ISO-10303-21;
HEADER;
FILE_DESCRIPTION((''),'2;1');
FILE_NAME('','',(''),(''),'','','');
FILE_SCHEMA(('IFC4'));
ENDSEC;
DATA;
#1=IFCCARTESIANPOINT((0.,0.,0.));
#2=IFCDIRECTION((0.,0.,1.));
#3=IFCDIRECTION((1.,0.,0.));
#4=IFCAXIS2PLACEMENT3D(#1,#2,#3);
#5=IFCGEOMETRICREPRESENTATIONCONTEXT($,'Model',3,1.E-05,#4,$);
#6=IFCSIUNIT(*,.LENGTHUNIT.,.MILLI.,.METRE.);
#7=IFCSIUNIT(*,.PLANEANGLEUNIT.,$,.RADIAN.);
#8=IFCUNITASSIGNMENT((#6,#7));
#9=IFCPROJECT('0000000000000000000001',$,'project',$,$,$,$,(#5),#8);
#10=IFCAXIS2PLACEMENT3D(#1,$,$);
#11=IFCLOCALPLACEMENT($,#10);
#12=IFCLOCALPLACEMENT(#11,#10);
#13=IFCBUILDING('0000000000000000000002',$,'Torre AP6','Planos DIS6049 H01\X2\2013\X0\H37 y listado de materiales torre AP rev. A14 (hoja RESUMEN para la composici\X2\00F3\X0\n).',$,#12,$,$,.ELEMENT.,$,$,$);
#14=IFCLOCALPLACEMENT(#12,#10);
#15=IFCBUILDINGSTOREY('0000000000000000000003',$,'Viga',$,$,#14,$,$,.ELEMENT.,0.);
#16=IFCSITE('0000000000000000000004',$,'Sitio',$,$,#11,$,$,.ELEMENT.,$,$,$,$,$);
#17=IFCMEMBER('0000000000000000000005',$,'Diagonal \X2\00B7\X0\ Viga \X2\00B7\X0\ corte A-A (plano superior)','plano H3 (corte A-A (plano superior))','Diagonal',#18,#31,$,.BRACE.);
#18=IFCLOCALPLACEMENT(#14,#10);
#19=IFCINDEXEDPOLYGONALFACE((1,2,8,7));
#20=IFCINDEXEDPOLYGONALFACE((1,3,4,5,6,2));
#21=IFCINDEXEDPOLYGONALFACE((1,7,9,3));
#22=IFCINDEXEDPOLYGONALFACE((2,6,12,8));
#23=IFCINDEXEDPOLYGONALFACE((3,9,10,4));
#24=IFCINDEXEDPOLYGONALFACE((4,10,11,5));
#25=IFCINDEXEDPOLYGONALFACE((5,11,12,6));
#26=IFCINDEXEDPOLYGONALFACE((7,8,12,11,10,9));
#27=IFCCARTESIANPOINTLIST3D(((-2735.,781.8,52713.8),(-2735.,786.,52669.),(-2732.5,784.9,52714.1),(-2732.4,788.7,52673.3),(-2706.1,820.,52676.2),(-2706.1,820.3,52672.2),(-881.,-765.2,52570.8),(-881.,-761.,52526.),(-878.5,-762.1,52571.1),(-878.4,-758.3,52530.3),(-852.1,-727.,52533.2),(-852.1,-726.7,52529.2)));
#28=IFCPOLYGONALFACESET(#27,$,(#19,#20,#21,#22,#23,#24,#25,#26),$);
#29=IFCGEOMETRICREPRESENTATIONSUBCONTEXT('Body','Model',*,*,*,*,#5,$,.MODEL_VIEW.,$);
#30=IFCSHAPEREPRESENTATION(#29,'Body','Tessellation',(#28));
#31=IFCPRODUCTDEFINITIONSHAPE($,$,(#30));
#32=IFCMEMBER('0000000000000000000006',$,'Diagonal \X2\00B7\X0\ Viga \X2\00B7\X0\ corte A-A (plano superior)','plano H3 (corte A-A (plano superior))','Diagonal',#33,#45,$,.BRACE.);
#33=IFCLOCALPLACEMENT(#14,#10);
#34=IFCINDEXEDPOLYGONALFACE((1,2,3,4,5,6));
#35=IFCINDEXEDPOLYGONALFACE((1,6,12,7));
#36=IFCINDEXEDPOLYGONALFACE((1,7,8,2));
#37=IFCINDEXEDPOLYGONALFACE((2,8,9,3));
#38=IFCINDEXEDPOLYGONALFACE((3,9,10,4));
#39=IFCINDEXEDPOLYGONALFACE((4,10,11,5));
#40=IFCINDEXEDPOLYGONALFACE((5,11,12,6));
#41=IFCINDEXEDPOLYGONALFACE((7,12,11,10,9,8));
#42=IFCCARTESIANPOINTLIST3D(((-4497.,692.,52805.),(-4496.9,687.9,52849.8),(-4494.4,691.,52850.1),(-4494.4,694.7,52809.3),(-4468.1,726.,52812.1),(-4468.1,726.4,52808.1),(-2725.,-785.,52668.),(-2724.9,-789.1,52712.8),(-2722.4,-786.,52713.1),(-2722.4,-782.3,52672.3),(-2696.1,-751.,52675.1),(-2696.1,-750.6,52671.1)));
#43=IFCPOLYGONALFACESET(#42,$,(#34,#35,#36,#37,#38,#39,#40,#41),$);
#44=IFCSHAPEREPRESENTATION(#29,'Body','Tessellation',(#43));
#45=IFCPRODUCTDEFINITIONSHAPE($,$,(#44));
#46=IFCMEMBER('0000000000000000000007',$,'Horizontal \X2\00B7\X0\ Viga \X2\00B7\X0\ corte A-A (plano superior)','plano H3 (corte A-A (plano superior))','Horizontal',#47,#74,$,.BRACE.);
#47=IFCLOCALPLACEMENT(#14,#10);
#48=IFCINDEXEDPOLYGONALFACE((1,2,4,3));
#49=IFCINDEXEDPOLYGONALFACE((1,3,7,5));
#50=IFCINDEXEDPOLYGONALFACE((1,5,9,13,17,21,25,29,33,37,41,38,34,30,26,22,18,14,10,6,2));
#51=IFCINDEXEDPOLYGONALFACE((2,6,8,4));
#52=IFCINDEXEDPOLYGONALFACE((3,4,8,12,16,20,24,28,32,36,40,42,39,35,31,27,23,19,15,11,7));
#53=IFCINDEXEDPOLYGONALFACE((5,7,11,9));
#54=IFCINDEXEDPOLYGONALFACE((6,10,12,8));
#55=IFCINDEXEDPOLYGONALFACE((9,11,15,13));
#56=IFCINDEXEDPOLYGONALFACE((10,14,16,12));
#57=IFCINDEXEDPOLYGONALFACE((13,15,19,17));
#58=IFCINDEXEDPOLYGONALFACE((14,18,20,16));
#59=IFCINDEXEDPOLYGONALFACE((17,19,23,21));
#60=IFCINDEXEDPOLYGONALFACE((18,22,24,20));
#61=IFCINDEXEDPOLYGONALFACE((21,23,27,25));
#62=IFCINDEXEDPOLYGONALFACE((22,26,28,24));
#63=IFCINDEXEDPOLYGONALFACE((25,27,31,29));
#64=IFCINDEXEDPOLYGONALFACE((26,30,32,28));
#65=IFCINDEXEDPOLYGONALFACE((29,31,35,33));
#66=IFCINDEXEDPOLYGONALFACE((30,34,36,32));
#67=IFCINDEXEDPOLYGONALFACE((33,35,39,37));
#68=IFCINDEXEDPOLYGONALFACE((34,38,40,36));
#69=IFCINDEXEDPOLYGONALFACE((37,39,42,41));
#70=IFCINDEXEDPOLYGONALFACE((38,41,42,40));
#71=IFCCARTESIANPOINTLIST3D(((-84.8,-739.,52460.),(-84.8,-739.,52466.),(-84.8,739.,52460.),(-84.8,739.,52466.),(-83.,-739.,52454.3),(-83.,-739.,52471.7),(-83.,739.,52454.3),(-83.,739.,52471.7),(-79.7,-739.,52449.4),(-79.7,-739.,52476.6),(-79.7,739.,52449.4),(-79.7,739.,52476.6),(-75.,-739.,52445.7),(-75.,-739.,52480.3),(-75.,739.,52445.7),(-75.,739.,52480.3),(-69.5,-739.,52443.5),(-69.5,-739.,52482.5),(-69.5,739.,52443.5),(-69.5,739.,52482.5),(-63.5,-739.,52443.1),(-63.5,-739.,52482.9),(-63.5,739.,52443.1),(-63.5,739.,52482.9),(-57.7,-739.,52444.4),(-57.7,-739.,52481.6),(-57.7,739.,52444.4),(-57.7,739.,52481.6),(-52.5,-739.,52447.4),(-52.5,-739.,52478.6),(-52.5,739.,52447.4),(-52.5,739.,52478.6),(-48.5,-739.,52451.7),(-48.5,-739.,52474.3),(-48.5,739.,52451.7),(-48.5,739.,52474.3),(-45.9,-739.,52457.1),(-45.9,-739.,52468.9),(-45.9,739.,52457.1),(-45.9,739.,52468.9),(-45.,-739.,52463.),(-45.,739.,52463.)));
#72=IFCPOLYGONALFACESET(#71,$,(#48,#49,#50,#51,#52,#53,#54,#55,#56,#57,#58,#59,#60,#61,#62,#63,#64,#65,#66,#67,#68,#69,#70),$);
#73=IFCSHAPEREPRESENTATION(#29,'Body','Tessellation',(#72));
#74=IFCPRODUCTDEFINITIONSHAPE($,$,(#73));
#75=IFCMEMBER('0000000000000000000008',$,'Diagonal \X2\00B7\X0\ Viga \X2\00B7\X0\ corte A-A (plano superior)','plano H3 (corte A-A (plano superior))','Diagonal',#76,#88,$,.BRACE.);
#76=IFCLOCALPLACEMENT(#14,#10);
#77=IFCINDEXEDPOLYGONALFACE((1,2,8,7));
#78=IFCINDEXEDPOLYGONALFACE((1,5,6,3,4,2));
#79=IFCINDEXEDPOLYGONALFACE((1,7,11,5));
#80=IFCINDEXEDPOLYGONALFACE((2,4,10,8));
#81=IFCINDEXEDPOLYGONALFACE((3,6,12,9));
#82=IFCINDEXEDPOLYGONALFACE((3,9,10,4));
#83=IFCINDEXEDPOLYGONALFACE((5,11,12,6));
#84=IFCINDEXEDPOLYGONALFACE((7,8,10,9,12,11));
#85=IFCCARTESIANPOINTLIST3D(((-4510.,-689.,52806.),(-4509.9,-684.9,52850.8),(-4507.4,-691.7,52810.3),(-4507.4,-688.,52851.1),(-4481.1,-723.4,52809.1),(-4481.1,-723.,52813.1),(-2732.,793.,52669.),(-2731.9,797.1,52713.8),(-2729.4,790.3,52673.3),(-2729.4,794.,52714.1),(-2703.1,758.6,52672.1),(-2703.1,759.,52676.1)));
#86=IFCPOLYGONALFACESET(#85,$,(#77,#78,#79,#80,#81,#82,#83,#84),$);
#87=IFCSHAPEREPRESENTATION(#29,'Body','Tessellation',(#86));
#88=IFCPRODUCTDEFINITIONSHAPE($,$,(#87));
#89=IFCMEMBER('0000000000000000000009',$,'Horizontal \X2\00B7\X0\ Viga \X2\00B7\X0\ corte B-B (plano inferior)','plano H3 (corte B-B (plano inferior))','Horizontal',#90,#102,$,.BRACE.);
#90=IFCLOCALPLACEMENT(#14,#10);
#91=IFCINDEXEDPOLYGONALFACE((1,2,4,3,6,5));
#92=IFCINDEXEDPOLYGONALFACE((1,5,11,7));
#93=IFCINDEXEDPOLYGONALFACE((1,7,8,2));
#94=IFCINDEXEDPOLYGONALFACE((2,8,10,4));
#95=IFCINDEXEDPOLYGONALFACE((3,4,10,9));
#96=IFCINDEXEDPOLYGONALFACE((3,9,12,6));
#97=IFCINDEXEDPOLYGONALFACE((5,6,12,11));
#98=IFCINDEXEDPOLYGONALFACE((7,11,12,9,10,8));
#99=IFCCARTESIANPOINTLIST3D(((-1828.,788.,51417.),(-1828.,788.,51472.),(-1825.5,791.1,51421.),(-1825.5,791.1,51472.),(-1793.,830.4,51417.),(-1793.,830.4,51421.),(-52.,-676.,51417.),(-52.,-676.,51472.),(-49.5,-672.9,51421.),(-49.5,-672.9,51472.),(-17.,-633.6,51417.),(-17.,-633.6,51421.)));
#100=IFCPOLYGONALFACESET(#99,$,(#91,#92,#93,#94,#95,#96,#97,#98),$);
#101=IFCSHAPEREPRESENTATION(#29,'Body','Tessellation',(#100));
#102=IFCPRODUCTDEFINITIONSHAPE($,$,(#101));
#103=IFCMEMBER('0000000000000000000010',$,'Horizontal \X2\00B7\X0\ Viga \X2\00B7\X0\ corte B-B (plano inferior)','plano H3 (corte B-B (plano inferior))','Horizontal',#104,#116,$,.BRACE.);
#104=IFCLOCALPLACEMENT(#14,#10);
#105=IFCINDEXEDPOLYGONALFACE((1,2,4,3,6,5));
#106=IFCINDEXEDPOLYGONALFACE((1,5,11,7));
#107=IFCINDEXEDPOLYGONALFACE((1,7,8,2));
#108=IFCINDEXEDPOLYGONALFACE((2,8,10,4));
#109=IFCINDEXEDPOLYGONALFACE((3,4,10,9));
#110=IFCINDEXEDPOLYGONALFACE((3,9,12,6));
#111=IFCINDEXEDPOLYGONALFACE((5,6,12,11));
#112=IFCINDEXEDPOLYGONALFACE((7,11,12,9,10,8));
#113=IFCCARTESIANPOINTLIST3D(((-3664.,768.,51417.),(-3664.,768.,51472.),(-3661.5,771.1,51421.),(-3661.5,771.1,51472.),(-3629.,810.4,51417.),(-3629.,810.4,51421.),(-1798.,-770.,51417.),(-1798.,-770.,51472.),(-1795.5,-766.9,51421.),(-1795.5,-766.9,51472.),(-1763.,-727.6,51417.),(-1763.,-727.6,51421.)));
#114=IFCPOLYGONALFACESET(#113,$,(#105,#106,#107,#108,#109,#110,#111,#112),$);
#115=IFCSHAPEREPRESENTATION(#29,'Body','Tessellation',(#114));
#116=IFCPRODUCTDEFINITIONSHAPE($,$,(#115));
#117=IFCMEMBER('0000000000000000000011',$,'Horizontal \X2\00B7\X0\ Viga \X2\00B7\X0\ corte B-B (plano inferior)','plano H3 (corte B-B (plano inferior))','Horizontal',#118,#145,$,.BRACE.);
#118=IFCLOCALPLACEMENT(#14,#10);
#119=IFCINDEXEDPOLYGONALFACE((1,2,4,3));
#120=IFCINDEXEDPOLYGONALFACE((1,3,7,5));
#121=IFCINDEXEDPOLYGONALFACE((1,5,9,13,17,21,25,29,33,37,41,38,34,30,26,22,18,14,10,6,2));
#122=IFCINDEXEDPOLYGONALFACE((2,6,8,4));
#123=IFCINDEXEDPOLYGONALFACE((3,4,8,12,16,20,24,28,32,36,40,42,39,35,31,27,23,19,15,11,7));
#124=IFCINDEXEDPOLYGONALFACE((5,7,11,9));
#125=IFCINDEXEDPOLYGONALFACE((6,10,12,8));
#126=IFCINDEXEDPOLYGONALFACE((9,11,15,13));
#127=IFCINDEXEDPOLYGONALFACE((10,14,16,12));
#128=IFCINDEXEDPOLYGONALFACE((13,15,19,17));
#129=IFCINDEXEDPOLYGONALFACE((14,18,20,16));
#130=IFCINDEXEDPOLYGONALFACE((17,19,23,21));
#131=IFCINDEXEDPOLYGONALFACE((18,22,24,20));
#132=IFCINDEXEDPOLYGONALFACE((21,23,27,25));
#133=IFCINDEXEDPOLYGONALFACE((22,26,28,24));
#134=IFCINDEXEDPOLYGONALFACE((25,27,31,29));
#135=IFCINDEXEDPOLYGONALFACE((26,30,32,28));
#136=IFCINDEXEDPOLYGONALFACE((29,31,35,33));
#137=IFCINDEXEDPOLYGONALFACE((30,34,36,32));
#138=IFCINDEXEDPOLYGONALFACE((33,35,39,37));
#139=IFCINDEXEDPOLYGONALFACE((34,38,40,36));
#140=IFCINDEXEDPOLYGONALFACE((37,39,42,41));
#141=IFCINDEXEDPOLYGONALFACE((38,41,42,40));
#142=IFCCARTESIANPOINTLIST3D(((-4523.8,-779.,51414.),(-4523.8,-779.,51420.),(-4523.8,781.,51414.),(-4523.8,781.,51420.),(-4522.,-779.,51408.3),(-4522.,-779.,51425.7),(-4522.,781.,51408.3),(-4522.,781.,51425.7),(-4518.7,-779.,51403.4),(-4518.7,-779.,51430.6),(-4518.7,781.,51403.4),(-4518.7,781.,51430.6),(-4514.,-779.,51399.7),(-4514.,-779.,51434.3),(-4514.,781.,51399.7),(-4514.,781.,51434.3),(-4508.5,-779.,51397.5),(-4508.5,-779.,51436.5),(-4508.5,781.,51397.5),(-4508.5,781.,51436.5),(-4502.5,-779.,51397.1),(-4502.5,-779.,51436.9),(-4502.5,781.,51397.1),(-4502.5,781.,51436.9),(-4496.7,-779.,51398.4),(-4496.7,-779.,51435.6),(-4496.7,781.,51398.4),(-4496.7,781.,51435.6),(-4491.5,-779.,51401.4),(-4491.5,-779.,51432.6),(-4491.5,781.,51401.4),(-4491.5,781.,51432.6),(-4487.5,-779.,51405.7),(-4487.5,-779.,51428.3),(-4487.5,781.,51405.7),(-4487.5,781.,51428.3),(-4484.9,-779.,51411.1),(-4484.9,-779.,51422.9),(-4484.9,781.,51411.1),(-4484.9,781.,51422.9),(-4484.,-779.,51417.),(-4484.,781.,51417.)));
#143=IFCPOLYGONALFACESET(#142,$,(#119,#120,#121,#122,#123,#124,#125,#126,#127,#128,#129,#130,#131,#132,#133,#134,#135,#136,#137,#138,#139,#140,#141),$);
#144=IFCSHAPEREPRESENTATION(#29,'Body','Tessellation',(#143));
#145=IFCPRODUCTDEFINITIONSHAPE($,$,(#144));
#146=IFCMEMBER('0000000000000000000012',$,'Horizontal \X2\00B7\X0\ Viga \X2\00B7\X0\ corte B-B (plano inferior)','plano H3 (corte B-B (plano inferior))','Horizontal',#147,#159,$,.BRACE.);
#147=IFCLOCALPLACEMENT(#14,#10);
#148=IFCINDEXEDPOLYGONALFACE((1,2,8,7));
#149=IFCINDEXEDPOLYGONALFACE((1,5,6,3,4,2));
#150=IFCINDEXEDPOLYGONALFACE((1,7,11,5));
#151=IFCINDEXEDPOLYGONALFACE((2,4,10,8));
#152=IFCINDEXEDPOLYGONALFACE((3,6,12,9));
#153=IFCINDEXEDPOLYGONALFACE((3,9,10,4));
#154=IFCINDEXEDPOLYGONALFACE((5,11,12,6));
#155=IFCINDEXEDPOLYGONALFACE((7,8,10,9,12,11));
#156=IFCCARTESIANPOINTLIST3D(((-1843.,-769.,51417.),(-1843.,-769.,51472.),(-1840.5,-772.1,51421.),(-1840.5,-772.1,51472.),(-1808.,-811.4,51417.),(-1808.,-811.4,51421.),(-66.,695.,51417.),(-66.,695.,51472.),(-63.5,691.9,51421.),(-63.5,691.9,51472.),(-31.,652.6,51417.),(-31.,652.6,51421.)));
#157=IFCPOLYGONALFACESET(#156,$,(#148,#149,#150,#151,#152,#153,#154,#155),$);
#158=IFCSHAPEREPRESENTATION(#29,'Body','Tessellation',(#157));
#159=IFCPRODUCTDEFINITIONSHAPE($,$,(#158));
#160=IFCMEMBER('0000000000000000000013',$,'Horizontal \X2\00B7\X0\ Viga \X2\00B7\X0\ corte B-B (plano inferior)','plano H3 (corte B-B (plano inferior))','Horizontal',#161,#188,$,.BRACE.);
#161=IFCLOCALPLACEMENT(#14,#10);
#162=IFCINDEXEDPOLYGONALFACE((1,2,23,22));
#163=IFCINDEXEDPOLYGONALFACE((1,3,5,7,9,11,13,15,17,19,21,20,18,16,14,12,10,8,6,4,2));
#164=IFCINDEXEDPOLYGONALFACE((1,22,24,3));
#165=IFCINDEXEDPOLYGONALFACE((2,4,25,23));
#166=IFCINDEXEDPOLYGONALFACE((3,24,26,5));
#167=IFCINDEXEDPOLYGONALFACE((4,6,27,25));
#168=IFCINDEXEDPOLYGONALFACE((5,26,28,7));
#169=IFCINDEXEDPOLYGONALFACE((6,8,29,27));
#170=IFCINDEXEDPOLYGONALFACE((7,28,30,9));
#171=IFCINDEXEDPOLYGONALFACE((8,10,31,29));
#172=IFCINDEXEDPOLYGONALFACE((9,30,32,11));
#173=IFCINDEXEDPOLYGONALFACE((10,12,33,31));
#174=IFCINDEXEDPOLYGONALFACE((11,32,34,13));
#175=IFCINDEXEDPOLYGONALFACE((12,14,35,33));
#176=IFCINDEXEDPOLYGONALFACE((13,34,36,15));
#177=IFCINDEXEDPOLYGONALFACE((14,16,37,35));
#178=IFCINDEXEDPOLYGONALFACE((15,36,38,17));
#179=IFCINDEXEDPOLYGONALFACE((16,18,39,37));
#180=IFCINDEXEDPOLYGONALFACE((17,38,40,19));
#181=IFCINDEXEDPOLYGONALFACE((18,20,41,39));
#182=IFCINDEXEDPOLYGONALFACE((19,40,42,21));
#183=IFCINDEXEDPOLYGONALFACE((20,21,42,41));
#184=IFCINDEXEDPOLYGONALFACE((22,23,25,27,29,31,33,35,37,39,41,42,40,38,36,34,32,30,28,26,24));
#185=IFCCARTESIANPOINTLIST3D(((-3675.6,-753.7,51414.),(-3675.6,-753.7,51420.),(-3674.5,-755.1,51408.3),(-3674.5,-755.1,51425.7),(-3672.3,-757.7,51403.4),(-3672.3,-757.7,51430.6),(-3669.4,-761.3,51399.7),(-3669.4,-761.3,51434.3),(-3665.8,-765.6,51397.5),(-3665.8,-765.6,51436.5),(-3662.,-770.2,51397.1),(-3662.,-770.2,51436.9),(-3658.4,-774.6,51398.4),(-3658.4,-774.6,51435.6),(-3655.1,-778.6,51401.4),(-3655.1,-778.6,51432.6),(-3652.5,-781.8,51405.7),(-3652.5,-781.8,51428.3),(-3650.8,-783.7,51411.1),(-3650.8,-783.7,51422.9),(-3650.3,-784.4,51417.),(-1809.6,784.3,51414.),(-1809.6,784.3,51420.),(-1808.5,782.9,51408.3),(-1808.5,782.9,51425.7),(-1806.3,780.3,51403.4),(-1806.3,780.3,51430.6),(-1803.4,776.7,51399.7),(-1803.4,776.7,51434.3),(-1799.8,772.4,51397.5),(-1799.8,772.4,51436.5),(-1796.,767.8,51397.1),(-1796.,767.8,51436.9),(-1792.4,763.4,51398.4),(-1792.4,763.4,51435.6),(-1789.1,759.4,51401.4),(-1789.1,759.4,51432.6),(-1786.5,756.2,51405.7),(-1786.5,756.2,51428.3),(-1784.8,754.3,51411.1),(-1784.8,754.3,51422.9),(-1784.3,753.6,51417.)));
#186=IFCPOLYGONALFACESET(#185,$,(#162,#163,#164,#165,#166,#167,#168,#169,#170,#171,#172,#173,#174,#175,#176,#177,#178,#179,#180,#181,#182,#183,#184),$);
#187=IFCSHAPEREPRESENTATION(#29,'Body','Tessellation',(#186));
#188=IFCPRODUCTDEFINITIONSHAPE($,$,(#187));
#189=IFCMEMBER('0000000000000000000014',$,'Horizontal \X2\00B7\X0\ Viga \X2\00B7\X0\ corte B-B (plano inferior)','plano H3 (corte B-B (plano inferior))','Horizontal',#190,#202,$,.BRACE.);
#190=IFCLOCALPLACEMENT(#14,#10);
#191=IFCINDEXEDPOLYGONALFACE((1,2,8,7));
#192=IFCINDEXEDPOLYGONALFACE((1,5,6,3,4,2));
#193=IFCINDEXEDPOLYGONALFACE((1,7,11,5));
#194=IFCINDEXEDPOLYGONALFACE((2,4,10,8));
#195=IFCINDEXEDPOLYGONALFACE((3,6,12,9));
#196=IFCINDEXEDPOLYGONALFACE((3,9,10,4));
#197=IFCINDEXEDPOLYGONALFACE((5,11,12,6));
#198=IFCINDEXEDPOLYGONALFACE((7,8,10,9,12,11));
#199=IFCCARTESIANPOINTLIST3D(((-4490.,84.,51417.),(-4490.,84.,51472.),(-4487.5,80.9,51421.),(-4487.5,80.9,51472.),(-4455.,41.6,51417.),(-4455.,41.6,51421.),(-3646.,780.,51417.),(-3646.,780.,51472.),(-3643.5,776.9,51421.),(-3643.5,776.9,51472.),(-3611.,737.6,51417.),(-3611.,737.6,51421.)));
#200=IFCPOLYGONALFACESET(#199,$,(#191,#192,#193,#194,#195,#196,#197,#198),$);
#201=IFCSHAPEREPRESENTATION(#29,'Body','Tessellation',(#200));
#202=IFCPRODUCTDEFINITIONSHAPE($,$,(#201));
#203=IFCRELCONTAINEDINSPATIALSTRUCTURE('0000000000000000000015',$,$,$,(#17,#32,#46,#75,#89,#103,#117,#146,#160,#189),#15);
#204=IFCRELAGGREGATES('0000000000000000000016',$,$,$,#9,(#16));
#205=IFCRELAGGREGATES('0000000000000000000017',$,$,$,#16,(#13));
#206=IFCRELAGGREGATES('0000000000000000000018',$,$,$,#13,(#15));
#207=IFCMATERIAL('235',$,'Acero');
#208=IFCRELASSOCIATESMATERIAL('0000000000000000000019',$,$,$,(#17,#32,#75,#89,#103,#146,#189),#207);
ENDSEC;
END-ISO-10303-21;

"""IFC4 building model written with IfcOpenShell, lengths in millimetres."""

from ifc_helpers import new_model, si_unit, frame, frame_2d, origin, origin_with_axes, place, context, subcontext, project, spatial, circle, l_section, extrude, material, element, save


model = new_model("IFC4")

# Units and contexts
model_context = context("Model", 3, precision=1e-05, world=origin_with_axes())
body_context = subcontext(model_context, "Body", "Model", "MODEL_VIEW")
ifc_project = project(units=[si_unit("LENGTHUNIT", "METRE", prefix="MILLI"), si_unit("PLANEANGLEUNIT", "RADIAN")], contexts=[model_context])

# Site, building, storey
site_placement = place(None, origin())
site = spatial("IfcSite", under=ifc_project, at=site_placement, Name="Sitio", CompositionType="ELEMENT")
building_placement = place(site_placement, origin())
building = spatial("IfcBuilding", under=site, at=building_placement, Name="Torre AP6", Description="Planos DIS6049 H01–H37 y listado de materiales torre AP rev. A14 (hoja RESUMEN para la composición).", CompositionType="ELEMENT")
storey_placement = place(building_placement, origin())
storey = spatial("IfcBuildingStorey", under=building, at=storey_placement, Name="Viga", CompositionType="ELEMENT", Elevation=0.0)

# Members
ifc_material = material(Name="235", Category="Acero")
member_1_placement = place(storey_placement, frame((-2735.0, 786.0, 52669.0), z_axis=(0.766471, -0.639553, -0.059118), x_axis=(0.642279, 0.763125, 0.071544)))
element("IfcMember", 1, at=member_1_placement, inside=storey, material=ifc_material, Name="Diagonal · Viga · corte A-A (plano superior)", Description="plano H3 (corte A-A (plano superior))", ObjectType="Diagonal", PredefinedType="BRACE", context=body_context, shape_type="SweptSolid", body=[
    extrude(l_section(Depth=45.0, Width=45.0, Thickness=4.0, at=frame_2d((22.5, 22.5))), None, (0.0, 0.0, 1.0), 2418.9),
])
member_2_placement = place(storey_placement, frame((-4497.0, 692.0, 52805.0), z_axis=(0.766799, -0.639144, -0.059284), x_axis=(0.641886, 0.763689, 0.069004)))
element("IfcMember", 2, at=member_2_placement, inside=storey, material=ifc_material, Name="Diagonal · Viga · corte A-A (plano superior)", Description="plano H3 (corte A-A (plano superior))", ObjectType="Diagonal", PredefinedType="BRACE", context=body_context, shape_type="SweptSolid", body=[
    extrude(l_section(Depth=45.0, Width=45.0, Thickness=4.0, at=frame_2d((22.5, 22.5))), None, (0.0, 0.0, 1.0), 2310.9),
])
member_3_placement = place(storey_placement, frame((-65.0, 739.0, 52463.0), z_axis=(0.0, -1.0, 0.0), x_axis=(1.0, 0.0, 0.0)))
element("IfcMember", 3, at=member_3_placement, inside=storey, Name="Horizontal · Viga · corte A-A (plano superior)", Description="plano H3 (corte A-A (plano superior))", ObjectType="Horizontal", PredefinedType="BRACE", context=body_context, shape_type="SweptSolid", body=[
    extrude(circle(Radius=20.0), None, (0.0, 0.0, 1.0), 1478.0),
])
member_4_placement = place(storey_placement, frame((-2732.0, 793.0, 52669.0), z_axis=(-0.766808, -0.639151, 0.059085), x_axis=(0.641875, -0.763738, 0.068568)))
element("IfcMember", 4, at=member_4_placement, inside=storey, material=ifc_material, Name="Diagonal · Viga · corte A-A (plano superior)", Description="plano H3 (corte A-A (plano superior))", ObjectType="Diagonal", PredefinedType="BRACE", context=body_context, shape_type="SweptSolid", body=[
    extrude(l_section(Depth=45.0, Width=45.0, Thickness=4.0, at=frame_2d((22.5, 22.5))), None, (0.0, 0.0, 1.0), 2318.7),
])
member_5_placement = place(storey_placement, frame((-1828.0, 788.0, 51417.0), z_axis=(0.771629, -0.636073, 0.0), x_axis=(0.636073, 0.771629, 0.0)))
element("IfcMember", 5, at=member_5_placement, inside=storey, material=ifc_material, Name="Horizontal · Viga · corte B-B (plano inferior)", Description="plano H3 (corte B-B (plano inferior))", ObjectType="Horizontal", PredefinedType="BRACE", context=body_context, shape_type="SweptSolid", body=[
    extrude(l_section(Depth=55.0, Width=55.0, Thickness=4.0, at=frame_2d((27.5, 27.5))), None, (0.0, 0.0, 1.0), 2301.6),
])
member_6_placement = place(storey_placement, frame((-3664.0, 768.0, 51417.0), z_axis=(0.771668, -0.636026, 0.0), x_axis=(0.636026, 0.771668, 0.0)))
element("IfcMember", 6, at=member_6_placement, inside=storey, material=ifc_material, Name="Horizontal · Viga · corte B-B (plano inferior)", Description="plano H3 (corte B-B (plano inferior))", ObjectType="Horizontal", PredefinedType="BRACE", context=body_context, shape_type="SweptSolid", body=[
    extrude(l_section(Depth=55.0, Width=55.0, Thickness=4.0, at=frame_2d((27.5, 27.5))), None, (0.0, 0.0, 1.0), 2418.1),
])
member_7_placement = place(storey_placement, frame((-4504.0, 781.0, 51417.0), z_axis=(0.0, -1.0, 0.0), x_axis=(1.0, 0.0, 0.0)))
element("IfcMember", 7, at=member_7_placement, inside=storey, Name="Horizontal · Viga · corte B-B (plano inferior)", Description="plano H3 (corte B-B (plano inferior))", ObjectType="Horizontal", PredefinedType="BRACE", context=body_context, shape_type="SweptSolid", body=[
    extrude(circle(Radius=20.0), None, (0.0, 0.0, 1.0), 1560.0),
])
member_8_placement = place(storey_placement, frame((-66.0, 695.0, 51417.0), z_axis=(-0.771805, -0.635859, 0.0), x_axis=(0.635859, -0.771805, 0.0)))
element("IfcMember", 8, at=member_8_placement, inside=storey, material=ifc_material, Name="Horizontal · Viga · corte B-B (plano inferior)", Description="plano H3 (corte B-B (plano inferior))", ObjectType="Horizontal", PredefinedType="BRACE", context=body_context, shape_type="SweptSolid", body=[
    extrude(l_section(Depth=55.0, Width=55.0, Thickness=4.0, at=frame_2d((27.5, 27.5))), None, (0.0, 0.0, 1.0), 2302.4),
])
member_9_placement = place(storey_placement, frame((-1797.0, 769.0, 51417.0), z_axis=(-0.771668, -0.636026, 0.0), x_axis=(0.636026, -0.771668, 0.0)))
element("IfcMember", 9, at=member_9_placement, inside=storey, Name="Horizontal · Viga · corte B-B (plano inferior)", Description="plano H3 (corte B-B (plano inferior))", ObjectType="Horizontal", PredefinedType="BRACE", context=body_context, shape_type="SweptSolid", body=[
    extrude(circle(Radius=20.0), None, (0.0, 0.0, 1.0), 2418.1),
])
member_10_placement = place(storey_placement, frame((-3646.0, 780.0, 51417.0), z_axis=(-0.771508, -0.63622, 0.0), x_axis=(0.63622, -0.771508, 0.0)))
element("IfcMember", 10, at=member_10_placement, inside=storey, material=ifc_material, Name="Horizontal · Viga · corte B-B (plano inferior)", Description="plano H3 (corte B-B (plano inferior))", ObjectType="Horizontal", PredefinedType="BRACE", context=body_context, shape_type="SweptSolid", body=[
    extrude(l_section(Depth=55.0, Width=55.0, Thickness=4.0, at=frame_2d((27.5, 27.5))), None, (0.0, 0.0, 1.0), 1094.0),
])

save(model, "model.ifc")
